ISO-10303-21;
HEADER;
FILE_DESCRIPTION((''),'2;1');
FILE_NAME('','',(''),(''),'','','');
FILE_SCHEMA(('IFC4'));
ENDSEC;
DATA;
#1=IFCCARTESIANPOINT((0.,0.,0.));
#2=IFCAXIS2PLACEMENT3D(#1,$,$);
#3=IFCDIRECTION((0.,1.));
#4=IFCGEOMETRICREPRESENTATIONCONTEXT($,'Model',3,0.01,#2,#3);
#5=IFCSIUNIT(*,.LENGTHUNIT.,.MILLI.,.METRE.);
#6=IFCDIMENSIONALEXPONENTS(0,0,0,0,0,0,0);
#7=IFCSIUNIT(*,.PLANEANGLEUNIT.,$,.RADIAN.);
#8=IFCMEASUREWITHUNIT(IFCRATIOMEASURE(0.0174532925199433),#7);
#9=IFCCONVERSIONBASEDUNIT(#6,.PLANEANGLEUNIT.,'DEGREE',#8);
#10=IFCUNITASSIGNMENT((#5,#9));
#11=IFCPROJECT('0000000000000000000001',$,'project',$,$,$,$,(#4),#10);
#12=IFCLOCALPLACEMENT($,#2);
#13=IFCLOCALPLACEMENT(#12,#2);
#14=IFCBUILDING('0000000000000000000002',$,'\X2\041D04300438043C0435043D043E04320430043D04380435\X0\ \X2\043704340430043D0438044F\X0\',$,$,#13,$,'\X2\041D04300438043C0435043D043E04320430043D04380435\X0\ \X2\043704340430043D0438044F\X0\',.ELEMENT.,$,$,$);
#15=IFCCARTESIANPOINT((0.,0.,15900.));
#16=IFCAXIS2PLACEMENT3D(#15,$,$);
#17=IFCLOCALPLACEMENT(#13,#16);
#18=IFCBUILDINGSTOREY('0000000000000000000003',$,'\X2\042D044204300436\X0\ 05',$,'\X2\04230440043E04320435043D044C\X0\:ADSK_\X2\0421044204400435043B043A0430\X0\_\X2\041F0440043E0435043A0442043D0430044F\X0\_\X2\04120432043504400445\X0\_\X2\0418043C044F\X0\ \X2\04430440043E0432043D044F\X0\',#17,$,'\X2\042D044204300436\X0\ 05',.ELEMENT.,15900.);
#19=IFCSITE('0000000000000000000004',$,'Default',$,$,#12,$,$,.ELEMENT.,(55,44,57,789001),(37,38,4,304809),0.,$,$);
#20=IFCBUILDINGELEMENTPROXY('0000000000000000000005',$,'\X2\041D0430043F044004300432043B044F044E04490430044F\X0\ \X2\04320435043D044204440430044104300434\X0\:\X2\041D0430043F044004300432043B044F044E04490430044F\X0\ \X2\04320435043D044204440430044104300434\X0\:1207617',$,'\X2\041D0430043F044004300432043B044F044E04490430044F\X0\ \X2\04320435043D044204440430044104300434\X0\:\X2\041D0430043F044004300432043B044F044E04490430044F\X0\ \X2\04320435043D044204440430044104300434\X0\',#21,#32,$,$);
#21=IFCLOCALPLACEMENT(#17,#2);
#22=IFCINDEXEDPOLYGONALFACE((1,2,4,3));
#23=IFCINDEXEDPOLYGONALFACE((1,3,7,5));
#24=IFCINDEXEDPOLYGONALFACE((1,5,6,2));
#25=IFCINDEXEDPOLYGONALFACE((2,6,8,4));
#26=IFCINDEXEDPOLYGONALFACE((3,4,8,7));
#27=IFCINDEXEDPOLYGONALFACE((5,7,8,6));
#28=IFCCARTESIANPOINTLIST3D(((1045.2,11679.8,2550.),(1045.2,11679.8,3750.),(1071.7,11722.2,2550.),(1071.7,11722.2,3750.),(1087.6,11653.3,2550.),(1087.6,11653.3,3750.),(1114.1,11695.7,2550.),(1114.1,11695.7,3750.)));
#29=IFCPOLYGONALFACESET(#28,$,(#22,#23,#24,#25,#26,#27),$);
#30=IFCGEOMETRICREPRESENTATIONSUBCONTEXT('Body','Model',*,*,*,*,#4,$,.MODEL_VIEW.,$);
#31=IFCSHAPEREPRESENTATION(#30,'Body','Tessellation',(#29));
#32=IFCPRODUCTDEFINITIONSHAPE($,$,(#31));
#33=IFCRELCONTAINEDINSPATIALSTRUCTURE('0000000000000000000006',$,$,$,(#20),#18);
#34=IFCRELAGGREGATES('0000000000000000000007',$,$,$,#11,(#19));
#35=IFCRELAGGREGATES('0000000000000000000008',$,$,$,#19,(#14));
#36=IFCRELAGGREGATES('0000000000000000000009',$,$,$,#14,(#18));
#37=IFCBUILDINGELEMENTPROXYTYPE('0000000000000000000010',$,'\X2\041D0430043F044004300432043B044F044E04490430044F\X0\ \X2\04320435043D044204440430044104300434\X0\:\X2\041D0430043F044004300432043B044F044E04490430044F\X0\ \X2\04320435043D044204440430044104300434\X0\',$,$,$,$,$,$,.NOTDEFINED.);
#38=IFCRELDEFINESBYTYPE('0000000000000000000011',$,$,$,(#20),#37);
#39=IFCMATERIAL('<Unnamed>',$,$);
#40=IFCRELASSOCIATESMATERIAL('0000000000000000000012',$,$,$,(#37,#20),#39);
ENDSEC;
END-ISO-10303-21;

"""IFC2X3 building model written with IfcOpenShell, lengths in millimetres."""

from ifc_helpers import new_model, entity, si_unit, converted_unit, direction, frame, origin, origin_2d_with_axis, place, context, subcontext, project, spatial, rectangle, extrude, source, transform, mapped, material, type_object, type_shapes, element, save


model = new_model("IFC2X3")

# Units and contexts
model_context = context("Model", 3, precision=0.01, world=origin(), true_north=direction((0.0, 1.0)))
body_context = subcontext(model_context, "Body", "Model", "MODEL_VIEW")
ifc_project = project(units=[si_unit("LENGTHUNIT", "METRE", prefix="MILLI"), converted_unit("PLANEANGLEUNIT", "DEGREE", entity("IfcRatioMeasure", 0.0174532925199433), si_unit("PLANEANGLEUNIT", "RADIAN"), dimensions=[0, 0, 0, 0, 0, 0, 0])], contexts=[model_context])

# Site, building, storey
site_placement = place(None, origin())
site = spatial("IfcSite", under=ifc_project, at=site_placement, Name="Default", CompositionType="ELEMENT", RefLatitude=(55, 44, 57, 789001), RefLongitude=(37, 38, 4, 304809), RefElevation=0.0)
building_placement = place(site_placement, origin())
building = spatial("IfcBuilding", under=site, at=building_placement, Name="Наименование здания", LongName="Наименование здания", CompositionType="ELEMENT")
storey_placement = place(building_placement, frame((0.0, 0.0, 15900.0)))
storey = spatial("IfcBuildingStorey", under=building, at=storey_placement, Name="Этаж 05", ObjectType="Уровень:ADSK_Стрелка_Проектная_Вверх_Имя уровня", LongName="Этаж 05", CompositionType="ELEMENT", Elevation=15900.0)

# Building element proxy
ifc_material_1 = material(Name="<Unnamed>")
building_element_proxy_type_1 = type_object("IfcBuildingElementProxyType", Name="Направляющая вентфасад:Направляющая вентфасад", PredefinedType="NOTDEFINED", material=ifc_material_1)
shared_shape_1 = source(origin(), body_context, "Body", "SweptSolid", [
    extrude(rectangle(XDim=50.0, YDim=50.0, at=origin_2d_with_axis()), frame((25.0, -25.0, 0.0), z_axis=(0.0, 0.0, 1.0), x_axis=(-1.0, 0.0, 0.0)), (0.0, 0.0, 1.0), 1200.0),
])
type_shapes(building_element_proxy_type_1, [shared_shape_1])
proxy_1_placement = place(storey_placement, frame((1071.7, 11722.2, 2550.0), z_axis=(0.0, 0.0, 1.0), x_axis=(0.848053, -0.529912, 0.0)))
element("IfcBuildingElementProxy", 1, at=proxy_1_placement, inside=storey, type_object=building_element_proxy_type_1, material=ifc_material_1, Name="Направляющая вентфасад:Направляющая вентфасад:1207617", ObjectType="Направляющая вентфасад:Направляющая вентфасад", context=body_context, shape_type="MappedRepresentation", body=[
    mapped(shared_shape_1, transform((0.0, 0.0, 0.0), scale=1.0)),
])

save(model, "model.ifc")
